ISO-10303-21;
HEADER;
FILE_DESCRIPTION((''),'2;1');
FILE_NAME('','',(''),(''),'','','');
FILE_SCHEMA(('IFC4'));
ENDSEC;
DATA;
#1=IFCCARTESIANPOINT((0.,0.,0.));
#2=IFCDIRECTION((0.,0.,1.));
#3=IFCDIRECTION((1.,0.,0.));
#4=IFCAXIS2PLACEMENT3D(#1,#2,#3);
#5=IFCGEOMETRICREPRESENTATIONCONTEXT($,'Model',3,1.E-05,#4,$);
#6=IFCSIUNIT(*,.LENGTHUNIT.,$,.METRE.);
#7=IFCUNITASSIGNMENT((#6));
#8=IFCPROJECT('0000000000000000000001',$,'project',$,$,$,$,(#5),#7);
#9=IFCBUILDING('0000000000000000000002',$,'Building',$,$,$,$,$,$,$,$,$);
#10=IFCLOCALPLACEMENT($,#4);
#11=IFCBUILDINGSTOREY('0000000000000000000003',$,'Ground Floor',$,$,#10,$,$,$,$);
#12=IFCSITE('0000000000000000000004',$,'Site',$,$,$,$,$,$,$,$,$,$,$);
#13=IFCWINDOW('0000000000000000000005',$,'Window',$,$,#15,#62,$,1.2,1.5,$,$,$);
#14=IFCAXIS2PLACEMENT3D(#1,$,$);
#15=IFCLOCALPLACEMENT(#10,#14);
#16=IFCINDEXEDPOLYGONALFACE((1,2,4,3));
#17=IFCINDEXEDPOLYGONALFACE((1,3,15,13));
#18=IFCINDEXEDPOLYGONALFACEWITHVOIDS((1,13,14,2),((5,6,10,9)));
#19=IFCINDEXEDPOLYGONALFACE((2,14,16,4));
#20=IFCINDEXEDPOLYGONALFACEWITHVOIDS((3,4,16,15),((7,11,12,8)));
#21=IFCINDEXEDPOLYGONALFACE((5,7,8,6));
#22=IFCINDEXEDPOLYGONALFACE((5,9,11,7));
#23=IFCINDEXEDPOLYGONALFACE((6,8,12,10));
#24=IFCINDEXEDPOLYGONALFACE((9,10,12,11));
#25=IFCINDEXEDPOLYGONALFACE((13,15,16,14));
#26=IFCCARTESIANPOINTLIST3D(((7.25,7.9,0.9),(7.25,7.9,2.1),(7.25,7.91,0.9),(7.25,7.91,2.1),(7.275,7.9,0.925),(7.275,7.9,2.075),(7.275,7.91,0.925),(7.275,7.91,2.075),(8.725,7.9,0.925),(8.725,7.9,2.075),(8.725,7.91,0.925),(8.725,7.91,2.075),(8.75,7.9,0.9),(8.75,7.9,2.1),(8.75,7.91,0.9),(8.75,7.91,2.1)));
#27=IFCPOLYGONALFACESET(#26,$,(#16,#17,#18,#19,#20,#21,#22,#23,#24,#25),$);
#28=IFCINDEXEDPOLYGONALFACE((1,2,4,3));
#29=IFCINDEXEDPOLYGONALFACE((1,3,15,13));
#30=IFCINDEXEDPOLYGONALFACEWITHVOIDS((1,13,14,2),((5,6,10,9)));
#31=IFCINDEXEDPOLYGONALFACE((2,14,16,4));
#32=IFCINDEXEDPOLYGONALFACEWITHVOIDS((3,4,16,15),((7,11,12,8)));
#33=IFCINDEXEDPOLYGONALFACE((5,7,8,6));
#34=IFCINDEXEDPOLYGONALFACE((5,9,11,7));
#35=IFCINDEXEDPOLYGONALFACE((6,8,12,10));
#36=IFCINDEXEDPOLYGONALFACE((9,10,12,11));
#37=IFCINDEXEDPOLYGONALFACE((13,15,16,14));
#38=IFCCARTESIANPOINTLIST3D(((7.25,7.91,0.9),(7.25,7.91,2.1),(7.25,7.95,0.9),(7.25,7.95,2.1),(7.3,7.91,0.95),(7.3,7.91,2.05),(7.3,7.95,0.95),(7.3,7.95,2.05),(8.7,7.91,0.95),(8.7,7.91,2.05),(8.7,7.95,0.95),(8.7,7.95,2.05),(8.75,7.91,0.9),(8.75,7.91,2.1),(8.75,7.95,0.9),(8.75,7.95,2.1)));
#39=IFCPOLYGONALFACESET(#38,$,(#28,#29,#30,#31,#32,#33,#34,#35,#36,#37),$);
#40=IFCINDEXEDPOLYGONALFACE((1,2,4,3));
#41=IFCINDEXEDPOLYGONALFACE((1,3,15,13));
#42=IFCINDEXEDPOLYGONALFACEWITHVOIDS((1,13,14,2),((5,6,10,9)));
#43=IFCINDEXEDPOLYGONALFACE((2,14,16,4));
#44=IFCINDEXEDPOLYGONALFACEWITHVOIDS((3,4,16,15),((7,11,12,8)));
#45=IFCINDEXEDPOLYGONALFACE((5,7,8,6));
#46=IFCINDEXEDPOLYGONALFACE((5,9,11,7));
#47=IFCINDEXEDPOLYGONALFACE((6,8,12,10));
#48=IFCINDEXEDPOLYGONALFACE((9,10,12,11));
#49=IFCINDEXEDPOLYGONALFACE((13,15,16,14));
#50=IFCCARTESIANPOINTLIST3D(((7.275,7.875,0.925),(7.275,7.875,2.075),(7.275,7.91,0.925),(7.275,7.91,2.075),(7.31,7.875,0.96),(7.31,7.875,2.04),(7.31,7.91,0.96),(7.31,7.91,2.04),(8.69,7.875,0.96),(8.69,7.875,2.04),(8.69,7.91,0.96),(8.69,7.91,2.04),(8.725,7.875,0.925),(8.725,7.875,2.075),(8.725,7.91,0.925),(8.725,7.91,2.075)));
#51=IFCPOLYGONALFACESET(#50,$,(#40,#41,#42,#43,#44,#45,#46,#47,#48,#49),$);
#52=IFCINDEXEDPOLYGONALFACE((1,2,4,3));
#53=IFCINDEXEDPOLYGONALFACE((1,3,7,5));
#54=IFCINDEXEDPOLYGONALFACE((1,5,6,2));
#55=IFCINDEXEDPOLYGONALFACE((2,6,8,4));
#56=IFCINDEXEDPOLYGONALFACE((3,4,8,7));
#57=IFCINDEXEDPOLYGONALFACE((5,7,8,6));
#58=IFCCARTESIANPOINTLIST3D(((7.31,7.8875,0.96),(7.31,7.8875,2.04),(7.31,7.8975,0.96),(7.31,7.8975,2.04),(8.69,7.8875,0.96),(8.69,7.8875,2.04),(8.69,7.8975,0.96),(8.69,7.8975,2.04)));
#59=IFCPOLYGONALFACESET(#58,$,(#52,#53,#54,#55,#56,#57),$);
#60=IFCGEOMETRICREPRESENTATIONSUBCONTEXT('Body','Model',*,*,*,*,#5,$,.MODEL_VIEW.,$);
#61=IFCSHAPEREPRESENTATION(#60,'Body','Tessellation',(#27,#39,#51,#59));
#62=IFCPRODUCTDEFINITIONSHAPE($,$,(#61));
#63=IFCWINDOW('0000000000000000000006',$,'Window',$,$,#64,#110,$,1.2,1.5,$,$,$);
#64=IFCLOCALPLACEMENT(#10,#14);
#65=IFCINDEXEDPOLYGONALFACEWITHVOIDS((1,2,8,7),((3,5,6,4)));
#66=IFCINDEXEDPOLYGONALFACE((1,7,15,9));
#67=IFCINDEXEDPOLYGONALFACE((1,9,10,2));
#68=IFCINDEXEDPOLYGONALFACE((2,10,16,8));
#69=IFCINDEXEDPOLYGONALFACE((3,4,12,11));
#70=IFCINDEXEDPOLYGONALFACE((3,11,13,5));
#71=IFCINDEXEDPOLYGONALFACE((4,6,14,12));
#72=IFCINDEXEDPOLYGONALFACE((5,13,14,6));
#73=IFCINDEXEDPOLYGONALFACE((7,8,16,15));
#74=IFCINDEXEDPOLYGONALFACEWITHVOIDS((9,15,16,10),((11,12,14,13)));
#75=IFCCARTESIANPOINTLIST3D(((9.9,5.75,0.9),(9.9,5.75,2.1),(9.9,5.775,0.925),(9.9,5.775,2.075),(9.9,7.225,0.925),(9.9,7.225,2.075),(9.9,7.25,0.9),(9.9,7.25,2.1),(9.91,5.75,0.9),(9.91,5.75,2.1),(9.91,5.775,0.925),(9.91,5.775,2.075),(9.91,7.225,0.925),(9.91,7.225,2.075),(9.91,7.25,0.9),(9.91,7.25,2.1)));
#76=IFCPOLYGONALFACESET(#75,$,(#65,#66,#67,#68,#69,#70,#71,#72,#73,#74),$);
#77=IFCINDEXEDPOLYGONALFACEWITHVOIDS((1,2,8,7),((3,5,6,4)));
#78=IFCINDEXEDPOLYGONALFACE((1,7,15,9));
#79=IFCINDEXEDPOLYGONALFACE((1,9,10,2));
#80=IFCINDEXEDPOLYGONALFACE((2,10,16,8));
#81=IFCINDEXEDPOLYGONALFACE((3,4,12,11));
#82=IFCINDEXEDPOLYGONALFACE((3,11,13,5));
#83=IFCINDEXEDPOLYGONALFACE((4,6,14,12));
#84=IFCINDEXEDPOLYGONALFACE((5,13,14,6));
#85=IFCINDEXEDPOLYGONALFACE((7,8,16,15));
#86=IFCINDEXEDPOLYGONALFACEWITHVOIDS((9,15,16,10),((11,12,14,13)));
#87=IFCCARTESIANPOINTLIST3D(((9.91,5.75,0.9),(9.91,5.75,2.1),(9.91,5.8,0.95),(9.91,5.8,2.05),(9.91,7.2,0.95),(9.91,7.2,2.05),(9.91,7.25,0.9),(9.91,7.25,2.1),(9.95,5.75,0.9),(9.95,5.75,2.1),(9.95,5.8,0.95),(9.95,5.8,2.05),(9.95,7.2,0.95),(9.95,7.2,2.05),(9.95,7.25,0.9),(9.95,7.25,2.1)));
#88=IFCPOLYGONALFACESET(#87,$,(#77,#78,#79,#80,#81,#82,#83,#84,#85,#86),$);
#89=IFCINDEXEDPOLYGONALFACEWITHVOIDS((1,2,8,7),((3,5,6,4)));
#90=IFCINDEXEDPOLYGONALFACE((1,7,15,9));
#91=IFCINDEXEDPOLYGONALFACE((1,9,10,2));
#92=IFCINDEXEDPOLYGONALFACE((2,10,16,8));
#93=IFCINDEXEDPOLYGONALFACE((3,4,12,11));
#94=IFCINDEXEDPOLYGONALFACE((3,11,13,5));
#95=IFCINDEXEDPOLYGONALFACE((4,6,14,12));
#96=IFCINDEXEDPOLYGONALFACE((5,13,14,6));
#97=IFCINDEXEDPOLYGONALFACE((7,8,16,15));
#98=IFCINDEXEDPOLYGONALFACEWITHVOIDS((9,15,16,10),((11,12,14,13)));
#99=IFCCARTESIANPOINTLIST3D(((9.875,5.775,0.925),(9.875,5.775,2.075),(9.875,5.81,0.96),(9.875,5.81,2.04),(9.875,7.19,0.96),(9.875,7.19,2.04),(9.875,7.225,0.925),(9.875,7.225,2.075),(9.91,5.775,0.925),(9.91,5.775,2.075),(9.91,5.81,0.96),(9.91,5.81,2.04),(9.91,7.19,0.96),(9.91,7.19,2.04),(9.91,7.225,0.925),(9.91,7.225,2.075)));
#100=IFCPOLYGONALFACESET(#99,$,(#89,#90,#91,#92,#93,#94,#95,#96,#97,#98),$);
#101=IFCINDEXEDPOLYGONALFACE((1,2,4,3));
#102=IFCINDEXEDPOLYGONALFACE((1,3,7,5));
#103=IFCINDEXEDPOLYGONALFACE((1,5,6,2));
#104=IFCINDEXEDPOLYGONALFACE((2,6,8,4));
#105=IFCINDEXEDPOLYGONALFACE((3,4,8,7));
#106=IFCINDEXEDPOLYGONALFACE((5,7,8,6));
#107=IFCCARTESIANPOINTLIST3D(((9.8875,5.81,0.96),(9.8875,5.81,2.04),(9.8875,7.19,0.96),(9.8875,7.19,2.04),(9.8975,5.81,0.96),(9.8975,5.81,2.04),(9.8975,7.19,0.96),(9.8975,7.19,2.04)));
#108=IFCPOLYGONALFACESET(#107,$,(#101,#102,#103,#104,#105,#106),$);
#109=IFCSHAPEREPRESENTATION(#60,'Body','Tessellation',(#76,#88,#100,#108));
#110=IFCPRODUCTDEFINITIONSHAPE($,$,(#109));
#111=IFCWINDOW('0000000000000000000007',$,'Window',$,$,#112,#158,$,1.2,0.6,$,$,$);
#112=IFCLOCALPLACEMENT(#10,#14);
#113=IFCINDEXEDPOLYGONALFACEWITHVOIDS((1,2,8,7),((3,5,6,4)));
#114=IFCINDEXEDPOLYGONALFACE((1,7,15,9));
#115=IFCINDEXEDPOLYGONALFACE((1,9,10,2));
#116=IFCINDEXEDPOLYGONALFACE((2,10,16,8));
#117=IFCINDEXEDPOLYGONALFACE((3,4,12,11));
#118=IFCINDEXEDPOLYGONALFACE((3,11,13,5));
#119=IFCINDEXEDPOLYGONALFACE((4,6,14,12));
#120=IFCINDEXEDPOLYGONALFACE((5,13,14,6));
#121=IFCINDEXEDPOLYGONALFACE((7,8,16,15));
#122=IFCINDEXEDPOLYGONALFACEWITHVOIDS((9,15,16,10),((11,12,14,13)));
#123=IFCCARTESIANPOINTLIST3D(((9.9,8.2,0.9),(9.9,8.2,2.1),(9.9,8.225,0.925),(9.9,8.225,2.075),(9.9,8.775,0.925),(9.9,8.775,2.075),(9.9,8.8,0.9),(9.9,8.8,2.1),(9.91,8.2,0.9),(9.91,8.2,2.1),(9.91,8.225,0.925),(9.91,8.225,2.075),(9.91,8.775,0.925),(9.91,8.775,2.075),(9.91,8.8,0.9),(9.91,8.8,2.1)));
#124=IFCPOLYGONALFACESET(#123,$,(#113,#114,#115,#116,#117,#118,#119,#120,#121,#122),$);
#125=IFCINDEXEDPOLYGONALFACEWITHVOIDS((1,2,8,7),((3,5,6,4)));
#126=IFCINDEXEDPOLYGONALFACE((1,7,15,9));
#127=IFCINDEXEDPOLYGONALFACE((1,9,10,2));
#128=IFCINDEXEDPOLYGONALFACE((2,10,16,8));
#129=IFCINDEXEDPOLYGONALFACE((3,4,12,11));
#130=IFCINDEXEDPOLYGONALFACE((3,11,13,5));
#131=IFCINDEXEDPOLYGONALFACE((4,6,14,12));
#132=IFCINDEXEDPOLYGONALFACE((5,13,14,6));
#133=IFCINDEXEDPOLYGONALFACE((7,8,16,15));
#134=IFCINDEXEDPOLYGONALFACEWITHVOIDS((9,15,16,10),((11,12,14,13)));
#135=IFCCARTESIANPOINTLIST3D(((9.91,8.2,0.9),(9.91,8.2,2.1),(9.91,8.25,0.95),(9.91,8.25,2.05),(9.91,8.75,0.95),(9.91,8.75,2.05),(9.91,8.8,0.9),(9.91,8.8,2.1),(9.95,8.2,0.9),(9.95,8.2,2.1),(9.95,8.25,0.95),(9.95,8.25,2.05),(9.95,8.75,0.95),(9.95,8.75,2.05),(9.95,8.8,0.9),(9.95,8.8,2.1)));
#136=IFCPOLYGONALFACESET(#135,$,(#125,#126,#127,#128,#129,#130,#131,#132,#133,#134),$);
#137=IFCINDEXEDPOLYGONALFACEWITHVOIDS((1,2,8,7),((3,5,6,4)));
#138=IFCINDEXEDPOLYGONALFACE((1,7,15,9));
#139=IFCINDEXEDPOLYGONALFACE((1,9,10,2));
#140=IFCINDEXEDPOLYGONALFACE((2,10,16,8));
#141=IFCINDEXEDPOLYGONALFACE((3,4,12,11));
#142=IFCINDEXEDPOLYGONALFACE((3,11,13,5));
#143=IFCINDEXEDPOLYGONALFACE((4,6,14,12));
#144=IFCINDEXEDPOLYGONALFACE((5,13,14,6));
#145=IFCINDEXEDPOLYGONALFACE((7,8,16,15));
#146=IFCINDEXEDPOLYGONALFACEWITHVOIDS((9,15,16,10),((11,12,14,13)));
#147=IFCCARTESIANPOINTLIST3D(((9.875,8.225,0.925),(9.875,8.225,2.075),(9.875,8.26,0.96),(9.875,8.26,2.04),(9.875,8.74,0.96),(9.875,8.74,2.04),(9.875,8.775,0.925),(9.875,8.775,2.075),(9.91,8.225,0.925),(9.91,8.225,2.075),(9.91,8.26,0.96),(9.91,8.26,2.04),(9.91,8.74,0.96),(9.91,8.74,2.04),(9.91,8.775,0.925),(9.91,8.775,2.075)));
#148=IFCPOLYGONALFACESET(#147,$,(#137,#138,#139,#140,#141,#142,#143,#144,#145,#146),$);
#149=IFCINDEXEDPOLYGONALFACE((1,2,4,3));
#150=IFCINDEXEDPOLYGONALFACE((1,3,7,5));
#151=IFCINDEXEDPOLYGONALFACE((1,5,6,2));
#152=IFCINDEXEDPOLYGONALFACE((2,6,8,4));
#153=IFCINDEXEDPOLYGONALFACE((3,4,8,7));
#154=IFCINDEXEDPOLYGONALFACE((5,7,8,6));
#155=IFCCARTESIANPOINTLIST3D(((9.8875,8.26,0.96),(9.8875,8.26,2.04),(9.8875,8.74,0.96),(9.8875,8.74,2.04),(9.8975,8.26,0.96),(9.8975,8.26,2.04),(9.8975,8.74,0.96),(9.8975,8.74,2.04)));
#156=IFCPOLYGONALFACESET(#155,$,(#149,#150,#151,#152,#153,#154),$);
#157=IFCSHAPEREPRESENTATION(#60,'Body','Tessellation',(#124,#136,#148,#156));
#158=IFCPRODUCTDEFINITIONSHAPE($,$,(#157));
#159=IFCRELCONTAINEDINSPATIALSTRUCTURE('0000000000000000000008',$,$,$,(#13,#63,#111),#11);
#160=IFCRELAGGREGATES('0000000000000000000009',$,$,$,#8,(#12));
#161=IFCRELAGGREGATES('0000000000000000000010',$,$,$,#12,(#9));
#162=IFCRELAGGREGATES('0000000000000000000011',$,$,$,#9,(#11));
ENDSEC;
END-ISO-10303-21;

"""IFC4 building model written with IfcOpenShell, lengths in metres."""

from ifc_helpers import new_model, si_unit, frame, origin_with_axes, place, context, subcontext, project, spatial, line, indexed_curve, outline, extrude, element, save


model = new_model("IFC4")

# Units and contexts
model_context = context("Model", 3, precision=1e-05, world=origin_with_axes())
body_context = subcontext(model_context, "Body", "Model", "MODEL_VIEW")
ifc_project = project(units=[si_unit("LENGTHUNIT", "METRE")], contexts=[model_context])

# Site, building, storey
site = spatial("IfcSite", under=ifc_project, Name="Site")
building = spatial("IfcBuilding", under=site, Name="Building")
storey_placement = place(None, origin_with_axes())
storey = spatial("IfcBuildingStorey", under=building, at=storey_placement, Name="Ground Floor")

# Windows
for number, where, z_axis, x_axis, name in (
    (1, (8.75, 8.0, 0.9), (0.0, 0.0, 1.0), (-1.0, 0.0, 0.0), "Window"),
    (2, (10.0, 5.75, 0.9), (0.0, 0.0, 1.0), (0.0, 1.0, 0.0), "Window"),
):
    element("IfcWindow", number, at=place(storey_placement, frame(where, z_axis=z_axis, x_axis=x_axis)), inside=storey, Name=name, OverallHeight=1.2, OverallWidth=1.5, context=body_context, shape_type="SweptSolid", body=[
        extrude(outline(indexed_curve([(0.0, 0.0), (1.5, 0.0), (1.5, 1.2), (0.0, 1.2)], segments=[line(1, 2, 3, 4, 1)]), holes=[indexed_curve([(0.025, 0.025), (1.475, 0.025), (1.475, 1.175), (0.025, 1.175)], segments=[line(1, 2, 3, 4, 1)])]), frame((0.0, 0.09, 0.0), z_axis=(0.0, -1.0, 0.0), x_axis=(1.0, 0.0, 0.0)), (0.0, 0.0, -1.0), 0.01),
        extrude(outline(indexed_curve([(0.0, 0.0), (1.5, 0.0), (1.5, 1.2), (0.0, 1.2)], segments=[line(1, 2, 3, 4, 1)]), holes=[indexed_curve([(0.05, 0.05), (1.45, 0.05), (1.45, 1.15), (0.05, 1.15)], segments=[line(1, 2, 3, 4, 1)])]), frame((0.0, 0.05, 0.0), z_axis=(0.0, -1.0, 0.0), x_axis=(1.0, 0.0, 0.0)), (0.0, 0.0, -1.0), 0.04),
        extrude(outline(indexed_curve([(0.0, 0.0), (1.45, 0.0), (1.45, 1.15), (0.0, 1.15)], segments=[line(1, 2, 3, 4, 1)]), holes=[indexed_curve([(0.035, 0.035), (1.415, 0.035), (1.415, 1.115), (0.035, 1.115)], segments=[line(1, 2, 3, 4, 1)])]), frame((0.025, 0.09, 0.025), z_axis=(0.0, -1.0, 0.0), x_axis=(1.0, 0.0, 0.0)), (0.0, 0.0, -1.0), 0.035),
        extrude(outline(indexed_curve([(0.035, 0.035), (1.415, 0.035), (1.415, 1.115), (0.035, 1.115)], segments=[line(1, 2, 3, 4, 1)])), frame((0.025, 0.1025, 0.025), z_axis=(0.0, -1.0, 0.0), x_axis=(1.0, 0.0, 0.0)), (0.0, 0.0, -1.0), 0.01),
    ])
window_1_placement = place(storey_placement, frame((10.0, 8.2, 0.9), z_axis=(0.0, 0.0, 1.0), x_axis=(0.0, 1.0, 0.0)))
element("IfcWindow", 3, at=window_1_placement, inside=storey, Name="Window", OverallHeight=1.2, OverallWidth=0.6, context=body_context, shape_type="SweptSolid", body=[
    extrude(outline(indexed_curve([(0.0, 0.0), (0.6, 0.0), (0.6, 1.2), (0.0, 1.2)], segments=[line(1, 2, 3, 4, 1)]), holes=[indexed_curve([(0.025, 0.025), (0.575, 0.025), (0.575, 1.175), (0.025, 1.175)], segments=[line(1, 2, 3, 4, 1)])]), frame((0.0, 0.09, 0.0), z_axis=(0.0, -1.0, 0.0), x_axis=(1.0, 0.0, 0.0)), (0.0, 0.0, -1.0), 0.01),
    extrude(outline(indexed_curve([(0.0, 0.0), (0.6, 0.0), (0.6, 1.2), (0.0, 1.2)], segments=[line(1, 2, 3, 4, 1)]), holes=[indexed_curve([(0.05, 0.05), (0.55, 0.05), (0.55, 1.15), (0.05, 1.15)], segments=[line(1, 2, 3, 4, 1)])]), frame((0.0, 0.05, 0.0), z_axis=(0.0, -1.0, 0.0), x_axis=(1.0, 0.0, 0.0)), (0.0, 0.0, -1.0), 0.04),
    extrude(outline(indexed_curve([(0.0, 0.0), (0.55, 0.0), (0.55, 1.15), (0.0, 1.15)], segments=[line(1, 2, 3, 4, 1)]), holes=[indexed_curve([(0.035, 0.035), (0.515, 0.035), (0.515, 1.115), (0.035, 1.115)], segments=[line(1, 2, 3, 4, 1)])]), frame((0.025, 0.09, 0.025), z_axis=(0.0, -1.0, 0.0), x_axis=(1.0, 0.0, 0.0)), (0.0, 0.0, -1.0), 0.035),
    extrude(outline(indexed_curve([(0.035, 0.035), (0.515, 0.035), (0.515, 1.115), (0.035, 1.115)], segments=[line(1, 2, 3, 4, 1)])), frame((0.025, 0.1025, 0.025), z_axis=(0.0, -1.0, 0.0), x_axis=(1.0, 0.0, 0.0)), (0.0, 0.0, -1.0), 0.01),
])

save(model, "model.ifc")
